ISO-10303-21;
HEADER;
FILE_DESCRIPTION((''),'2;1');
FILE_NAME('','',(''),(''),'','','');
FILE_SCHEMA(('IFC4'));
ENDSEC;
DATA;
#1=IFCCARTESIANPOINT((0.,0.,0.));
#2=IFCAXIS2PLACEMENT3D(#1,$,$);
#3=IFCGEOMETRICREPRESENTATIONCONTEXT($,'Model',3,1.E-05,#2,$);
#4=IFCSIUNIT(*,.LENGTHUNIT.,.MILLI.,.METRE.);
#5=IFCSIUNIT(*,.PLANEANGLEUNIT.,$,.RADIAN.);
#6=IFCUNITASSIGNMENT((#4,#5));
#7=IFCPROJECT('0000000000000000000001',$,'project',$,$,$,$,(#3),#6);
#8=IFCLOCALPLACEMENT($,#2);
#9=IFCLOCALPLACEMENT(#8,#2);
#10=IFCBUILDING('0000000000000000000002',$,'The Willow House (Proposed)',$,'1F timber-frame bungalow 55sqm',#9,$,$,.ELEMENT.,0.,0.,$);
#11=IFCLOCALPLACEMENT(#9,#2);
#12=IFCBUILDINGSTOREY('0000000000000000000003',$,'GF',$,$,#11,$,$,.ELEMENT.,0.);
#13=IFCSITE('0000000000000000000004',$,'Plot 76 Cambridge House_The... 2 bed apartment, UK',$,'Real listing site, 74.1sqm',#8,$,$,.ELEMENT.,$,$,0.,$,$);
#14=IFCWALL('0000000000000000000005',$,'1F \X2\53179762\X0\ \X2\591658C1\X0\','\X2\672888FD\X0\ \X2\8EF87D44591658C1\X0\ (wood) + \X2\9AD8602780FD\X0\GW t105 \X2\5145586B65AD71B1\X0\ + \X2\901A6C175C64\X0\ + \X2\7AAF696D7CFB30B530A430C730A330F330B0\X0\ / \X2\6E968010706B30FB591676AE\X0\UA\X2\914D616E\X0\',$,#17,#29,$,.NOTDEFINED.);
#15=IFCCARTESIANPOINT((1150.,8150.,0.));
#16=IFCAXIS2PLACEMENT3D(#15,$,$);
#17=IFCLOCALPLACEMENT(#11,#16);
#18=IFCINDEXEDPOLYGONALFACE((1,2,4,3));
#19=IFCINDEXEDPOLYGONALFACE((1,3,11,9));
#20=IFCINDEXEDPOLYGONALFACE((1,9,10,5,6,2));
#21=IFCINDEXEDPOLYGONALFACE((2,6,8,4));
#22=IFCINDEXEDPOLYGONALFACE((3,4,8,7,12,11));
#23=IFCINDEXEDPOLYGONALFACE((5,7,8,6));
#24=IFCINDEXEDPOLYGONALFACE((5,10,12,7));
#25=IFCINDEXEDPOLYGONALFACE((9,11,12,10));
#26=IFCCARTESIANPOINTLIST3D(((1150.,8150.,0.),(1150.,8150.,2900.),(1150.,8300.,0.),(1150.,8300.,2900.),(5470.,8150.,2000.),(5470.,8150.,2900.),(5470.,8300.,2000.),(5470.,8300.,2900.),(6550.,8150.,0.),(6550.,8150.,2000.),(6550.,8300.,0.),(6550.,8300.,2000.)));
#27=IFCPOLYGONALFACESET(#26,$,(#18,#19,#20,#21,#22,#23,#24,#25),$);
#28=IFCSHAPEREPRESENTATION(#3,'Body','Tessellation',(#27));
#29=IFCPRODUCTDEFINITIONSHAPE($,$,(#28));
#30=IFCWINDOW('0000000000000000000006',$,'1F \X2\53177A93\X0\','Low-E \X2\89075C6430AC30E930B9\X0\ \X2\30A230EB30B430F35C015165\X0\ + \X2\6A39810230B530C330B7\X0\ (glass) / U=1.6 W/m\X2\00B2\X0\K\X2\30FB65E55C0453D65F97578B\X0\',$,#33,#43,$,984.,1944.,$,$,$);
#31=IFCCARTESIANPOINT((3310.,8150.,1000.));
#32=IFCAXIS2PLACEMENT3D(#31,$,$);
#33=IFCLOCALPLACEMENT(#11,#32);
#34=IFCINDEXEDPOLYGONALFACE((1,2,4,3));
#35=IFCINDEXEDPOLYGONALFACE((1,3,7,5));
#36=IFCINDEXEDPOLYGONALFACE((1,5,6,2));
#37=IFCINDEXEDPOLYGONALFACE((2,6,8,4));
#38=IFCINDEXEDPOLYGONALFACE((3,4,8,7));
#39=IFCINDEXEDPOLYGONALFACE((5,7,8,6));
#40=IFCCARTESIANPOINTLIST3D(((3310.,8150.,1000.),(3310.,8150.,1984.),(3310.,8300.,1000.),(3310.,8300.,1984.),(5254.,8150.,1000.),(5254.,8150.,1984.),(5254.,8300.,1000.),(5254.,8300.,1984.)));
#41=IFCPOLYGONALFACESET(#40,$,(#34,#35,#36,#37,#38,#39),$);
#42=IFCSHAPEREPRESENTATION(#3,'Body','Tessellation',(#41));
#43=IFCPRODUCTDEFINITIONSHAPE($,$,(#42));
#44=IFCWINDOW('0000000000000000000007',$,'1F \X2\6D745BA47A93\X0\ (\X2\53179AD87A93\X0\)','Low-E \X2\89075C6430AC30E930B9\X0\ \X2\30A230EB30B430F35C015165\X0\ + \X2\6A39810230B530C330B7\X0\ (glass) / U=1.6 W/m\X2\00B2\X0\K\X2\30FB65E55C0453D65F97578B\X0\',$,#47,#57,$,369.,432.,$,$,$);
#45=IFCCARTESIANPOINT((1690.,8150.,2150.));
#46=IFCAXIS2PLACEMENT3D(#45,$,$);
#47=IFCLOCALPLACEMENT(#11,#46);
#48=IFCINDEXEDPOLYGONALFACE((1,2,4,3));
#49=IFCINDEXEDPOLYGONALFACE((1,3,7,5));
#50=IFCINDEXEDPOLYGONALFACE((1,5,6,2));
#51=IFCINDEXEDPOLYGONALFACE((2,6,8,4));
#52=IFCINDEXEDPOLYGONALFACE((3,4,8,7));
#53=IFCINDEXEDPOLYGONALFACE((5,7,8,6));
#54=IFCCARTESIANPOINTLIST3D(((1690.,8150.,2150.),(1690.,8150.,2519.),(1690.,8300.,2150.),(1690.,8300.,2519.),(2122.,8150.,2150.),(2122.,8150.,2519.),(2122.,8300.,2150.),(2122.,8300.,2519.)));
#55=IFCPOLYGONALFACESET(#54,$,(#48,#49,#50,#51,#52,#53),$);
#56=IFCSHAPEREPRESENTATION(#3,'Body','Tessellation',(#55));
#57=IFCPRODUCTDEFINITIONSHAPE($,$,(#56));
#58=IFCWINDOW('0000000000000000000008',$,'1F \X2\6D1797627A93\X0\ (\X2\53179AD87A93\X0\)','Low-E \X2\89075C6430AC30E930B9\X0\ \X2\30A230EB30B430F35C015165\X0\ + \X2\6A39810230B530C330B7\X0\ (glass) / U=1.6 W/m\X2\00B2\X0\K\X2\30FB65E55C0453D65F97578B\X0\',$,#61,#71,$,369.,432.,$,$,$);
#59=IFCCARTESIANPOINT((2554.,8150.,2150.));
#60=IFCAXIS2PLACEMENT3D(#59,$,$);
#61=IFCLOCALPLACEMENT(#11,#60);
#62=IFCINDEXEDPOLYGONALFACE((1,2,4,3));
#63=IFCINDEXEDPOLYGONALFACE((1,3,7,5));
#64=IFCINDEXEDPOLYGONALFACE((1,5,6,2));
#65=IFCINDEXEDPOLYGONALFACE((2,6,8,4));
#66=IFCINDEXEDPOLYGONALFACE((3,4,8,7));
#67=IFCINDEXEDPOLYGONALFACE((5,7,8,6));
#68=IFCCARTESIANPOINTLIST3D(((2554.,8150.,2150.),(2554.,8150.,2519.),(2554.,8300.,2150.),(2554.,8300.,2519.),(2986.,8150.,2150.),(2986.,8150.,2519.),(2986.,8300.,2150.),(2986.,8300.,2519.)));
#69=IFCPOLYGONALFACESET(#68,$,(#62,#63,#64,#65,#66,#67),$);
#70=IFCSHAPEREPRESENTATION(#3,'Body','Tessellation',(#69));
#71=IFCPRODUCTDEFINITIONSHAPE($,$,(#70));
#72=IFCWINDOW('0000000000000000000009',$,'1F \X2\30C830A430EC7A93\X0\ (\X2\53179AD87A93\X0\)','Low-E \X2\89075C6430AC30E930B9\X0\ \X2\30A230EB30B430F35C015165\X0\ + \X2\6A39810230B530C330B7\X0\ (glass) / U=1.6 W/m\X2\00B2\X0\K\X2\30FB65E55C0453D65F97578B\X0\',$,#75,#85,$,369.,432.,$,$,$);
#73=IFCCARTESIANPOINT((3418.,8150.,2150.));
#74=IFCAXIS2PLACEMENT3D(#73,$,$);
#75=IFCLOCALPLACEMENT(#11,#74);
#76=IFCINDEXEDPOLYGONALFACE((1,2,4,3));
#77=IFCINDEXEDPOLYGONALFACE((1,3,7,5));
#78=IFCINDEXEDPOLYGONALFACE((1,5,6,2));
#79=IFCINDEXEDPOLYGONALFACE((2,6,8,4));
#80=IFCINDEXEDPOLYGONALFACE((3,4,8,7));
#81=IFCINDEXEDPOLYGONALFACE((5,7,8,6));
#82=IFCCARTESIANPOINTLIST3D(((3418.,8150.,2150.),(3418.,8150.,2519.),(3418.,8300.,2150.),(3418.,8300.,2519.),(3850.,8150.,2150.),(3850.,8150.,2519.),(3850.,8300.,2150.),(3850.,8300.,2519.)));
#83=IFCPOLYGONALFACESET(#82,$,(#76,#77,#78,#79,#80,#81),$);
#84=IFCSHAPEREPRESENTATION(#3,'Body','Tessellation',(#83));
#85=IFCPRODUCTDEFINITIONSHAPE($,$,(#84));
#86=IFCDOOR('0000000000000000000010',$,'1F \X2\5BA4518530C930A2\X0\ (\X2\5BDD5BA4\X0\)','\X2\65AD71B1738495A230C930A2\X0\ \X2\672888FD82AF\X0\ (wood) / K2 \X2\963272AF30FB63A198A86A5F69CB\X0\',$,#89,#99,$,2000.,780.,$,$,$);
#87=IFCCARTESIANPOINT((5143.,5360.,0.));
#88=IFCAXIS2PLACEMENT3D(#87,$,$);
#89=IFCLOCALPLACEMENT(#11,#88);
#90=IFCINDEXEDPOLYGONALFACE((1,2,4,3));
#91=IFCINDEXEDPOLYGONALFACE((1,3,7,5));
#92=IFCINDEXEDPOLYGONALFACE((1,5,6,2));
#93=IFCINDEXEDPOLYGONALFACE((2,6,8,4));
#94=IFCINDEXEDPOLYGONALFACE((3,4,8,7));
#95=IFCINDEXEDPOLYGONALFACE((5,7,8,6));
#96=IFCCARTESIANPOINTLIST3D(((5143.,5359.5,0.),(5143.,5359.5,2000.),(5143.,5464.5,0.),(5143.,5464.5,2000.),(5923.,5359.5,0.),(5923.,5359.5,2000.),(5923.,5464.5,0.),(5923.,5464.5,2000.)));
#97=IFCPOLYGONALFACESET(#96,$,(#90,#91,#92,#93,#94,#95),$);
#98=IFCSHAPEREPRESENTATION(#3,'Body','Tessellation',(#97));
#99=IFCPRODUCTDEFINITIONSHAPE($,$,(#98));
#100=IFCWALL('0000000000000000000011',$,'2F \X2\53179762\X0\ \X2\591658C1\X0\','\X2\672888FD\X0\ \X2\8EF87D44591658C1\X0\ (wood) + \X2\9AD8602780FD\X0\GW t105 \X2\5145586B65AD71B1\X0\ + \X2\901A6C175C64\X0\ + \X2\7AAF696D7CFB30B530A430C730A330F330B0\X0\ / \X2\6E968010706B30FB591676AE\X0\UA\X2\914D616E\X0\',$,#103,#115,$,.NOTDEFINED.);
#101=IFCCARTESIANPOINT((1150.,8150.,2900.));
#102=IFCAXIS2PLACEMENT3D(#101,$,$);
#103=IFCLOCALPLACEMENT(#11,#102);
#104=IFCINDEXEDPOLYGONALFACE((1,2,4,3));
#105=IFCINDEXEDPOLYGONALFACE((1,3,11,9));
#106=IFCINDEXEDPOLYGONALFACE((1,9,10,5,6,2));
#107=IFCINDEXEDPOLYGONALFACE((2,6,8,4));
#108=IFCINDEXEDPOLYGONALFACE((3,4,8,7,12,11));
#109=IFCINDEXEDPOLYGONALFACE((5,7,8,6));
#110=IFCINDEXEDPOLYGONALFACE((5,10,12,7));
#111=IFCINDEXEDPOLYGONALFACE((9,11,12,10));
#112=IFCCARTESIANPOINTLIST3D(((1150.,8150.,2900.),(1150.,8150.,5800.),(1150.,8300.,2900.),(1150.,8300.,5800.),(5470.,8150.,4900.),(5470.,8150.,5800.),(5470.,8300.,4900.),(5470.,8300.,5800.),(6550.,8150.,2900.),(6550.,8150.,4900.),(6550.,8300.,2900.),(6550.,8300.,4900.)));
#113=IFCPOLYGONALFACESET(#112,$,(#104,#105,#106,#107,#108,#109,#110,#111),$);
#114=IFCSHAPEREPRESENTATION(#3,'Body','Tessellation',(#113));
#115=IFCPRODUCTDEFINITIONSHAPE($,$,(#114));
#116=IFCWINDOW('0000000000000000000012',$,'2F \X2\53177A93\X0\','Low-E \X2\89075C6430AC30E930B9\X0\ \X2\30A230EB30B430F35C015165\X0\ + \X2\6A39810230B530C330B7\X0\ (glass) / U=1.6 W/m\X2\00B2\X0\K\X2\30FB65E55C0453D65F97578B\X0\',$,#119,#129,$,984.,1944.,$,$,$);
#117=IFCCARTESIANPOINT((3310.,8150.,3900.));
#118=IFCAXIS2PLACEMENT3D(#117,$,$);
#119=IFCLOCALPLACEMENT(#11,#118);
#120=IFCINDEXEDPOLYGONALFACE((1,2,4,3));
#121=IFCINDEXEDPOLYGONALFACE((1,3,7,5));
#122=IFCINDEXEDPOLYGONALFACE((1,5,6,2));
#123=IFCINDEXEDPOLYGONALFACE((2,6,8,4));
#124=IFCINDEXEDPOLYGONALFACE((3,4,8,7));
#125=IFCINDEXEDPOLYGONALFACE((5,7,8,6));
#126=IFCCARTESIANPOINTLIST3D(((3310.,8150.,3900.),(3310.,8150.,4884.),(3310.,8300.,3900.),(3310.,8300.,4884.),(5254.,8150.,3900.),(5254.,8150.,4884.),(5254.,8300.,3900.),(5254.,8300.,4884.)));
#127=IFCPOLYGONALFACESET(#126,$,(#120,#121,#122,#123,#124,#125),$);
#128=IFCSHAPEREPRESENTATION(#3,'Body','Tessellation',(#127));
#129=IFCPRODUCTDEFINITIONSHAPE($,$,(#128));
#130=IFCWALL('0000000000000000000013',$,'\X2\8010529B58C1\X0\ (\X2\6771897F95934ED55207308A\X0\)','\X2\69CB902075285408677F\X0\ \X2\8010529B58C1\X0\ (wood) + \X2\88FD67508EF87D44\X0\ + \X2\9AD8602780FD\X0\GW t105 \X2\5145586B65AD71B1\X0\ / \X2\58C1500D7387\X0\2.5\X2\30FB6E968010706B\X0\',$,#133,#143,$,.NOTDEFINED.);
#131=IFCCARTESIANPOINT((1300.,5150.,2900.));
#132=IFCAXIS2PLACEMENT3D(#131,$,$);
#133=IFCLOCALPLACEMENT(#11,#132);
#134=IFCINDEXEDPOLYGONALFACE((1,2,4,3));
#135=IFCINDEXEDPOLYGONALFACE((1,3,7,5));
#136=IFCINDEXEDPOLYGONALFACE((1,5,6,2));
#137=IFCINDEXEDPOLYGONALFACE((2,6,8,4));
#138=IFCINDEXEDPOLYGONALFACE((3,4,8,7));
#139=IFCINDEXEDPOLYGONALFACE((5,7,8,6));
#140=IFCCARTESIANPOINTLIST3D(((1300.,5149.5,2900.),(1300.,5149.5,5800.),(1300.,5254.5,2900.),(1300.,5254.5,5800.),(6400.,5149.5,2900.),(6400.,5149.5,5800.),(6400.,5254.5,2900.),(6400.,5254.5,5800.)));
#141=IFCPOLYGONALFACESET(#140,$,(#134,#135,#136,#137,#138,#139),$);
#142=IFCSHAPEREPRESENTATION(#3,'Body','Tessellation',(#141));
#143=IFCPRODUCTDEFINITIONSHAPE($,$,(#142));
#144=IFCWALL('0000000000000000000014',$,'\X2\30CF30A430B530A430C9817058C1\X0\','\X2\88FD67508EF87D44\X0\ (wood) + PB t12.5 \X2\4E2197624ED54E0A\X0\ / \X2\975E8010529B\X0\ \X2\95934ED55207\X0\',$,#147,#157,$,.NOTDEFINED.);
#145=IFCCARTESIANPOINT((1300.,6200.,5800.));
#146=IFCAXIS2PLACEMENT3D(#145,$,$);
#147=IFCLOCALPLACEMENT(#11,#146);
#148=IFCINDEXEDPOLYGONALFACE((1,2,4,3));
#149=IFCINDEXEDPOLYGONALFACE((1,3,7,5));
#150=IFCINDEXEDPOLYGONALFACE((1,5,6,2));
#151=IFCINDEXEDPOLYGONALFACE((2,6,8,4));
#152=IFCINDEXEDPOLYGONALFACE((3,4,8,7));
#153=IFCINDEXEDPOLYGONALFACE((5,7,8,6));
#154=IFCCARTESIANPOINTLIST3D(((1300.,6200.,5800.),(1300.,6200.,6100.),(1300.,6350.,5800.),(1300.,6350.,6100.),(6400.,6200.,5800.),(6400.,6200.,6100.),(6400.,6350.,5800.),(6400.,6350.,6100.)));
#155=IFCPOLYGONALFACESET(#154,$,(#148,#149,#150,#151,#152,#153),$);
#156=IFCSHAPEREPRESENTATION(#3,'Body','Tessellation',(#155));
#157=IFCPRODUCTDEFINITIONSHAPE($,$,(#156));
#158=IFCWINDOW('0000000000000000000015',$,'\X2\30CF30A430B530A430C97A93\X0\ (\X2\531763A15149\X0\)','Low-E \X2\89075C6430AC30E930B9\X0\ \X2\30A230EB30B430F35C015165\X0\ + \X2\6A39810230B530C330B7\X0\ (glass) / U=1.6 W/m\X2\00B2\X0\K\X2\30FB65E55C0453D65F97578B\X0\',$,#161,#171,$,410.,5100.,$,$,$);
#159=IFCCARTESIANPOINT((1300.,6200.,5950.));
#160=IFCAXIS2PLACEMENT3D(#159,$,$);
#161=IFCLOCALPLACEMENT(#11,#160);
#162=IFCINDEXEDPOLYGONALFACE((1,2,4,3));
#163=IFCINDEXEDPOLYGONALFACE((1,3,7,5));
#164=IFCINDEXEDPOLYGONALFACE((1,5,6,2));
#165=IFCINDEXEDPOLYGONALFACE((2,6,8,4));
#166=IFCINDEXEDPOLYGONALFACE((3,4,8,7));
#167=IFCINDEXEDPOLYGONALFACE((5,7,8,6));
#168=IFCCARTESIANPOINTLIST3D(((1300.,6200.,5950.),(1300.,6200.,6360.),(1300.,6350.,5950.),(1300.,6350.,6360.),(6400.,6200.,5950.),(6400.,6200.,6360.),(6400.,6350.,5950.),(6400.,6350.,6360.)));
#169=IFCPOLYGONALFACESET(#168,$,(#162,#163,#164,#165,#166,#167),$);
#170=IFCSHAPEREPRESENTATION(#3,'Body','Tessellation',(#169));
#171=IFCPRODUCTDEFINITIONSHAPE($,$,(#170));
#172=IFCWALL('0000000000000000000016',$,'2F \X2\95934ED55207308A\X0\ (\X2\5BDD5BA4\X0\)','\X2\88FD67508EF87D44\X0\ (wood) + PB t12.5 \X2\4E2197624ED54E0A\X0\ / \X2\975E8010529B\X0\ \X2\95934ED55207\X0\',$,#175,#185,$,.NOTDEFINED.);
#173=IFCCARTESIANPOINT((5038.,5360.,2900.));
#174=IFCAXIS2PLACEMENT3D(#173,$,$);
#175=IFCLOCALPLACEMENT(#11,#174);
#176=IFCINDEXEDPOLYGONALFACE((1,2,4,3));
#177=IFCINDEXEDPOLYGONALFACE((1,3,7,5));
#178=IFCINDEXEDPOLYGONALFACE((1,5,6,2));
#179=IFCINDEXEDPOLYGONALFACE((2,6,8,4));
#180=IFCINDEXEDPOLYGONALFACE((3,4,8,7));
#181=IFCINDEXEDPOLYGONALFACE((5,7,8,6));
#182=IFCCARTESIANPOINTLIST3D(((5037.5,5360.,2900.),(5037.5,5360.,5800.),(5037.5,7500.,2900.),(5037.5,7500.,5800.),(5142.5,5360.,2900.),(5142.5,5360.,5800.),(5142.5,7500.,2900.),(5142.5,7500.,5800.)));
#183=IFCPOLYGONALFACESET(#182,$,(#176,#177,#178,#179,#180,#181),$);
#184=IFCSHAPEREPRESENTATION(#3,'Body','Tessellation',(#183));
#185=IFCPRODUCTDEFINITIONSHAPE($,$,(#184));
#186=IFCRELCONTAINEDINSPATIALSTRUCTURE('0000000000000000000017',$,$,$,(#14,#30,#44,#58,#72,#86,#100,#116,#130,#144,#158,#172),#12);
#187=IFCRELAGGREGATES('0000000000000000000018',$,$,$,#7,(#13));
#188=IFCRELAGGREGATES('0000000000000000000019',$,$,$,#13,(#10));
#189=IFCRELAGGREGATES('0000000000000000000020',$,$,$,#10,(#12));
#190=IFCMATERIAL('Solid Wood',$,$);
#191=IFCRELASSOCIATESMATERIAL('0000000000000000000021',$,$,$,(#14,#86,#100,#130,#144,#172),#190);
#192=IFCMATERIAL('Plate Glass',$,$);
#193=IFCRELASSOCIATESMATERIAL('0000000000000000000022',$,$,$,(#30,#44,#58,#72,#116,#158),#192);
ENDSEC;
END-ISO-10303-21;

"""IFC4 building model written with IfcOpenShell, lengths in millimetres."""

from ifc_helpers import new_model, si_unit, frame, frame_2d, origin, place, context, project, spatial, rectangle, extrude, material, element, fill, save


model = new_model("IFC4")

# Units and contexts
model_context = context("Model", 3, precision=1e-05, world=origin())
ifc_project = project(units=[si_unit("LENGTHUNIT", "METRE", prefix="MILLI"), si_unit("PLANEANGLEUNIT", "RADIAN")], contexts=[model_context])

# Site, building, storey
site_placement = place(None, origin())
site = spatial("IfcSite", under=ifc_project, at=site_placement, Name="Plot 76 Cambridge House_The... 2 bed apartment, UK", ObjectType="Real listing site, 74.1sqm", CompositionType="ELEMENT", RefElevation=0.0)
building_placement = place(site_placement, origin())
building = spatial("IfcBuilding", under=site, at=building_placement, Name="The Willow House (Proposed)", ObjectType="1F timber-frame bungalow 55sqm", CompositionType="ELEMENT", ElevationOfRefHeight=0.0, ElevationOfTerrain=0.0)
storey_placement = place(building_placement, origin())
storey = spatial("IfcBuildingStorey", under=building, at=storey_placement, Name="GF", CompositionType="ELEMENT", Elevation=0.0)

# Wall, openings, windows
ifc_material_1 = material(Name="Solid Wood")
wall_1_placement = place(storey_placement, frame((1150.0, 8150.0, 0.0)))
wall_1 = element("IfcWall", 1, at=wall_1_placement, inside=storey, material=ifc_material_1, Name="1F 北面 外壁", Description="木製 軸組外壁 (wood) + 高性能GW t105 充填断熱 + 通気層 + 窯業系サイディング / 準耐火・外皮UA配慮", PredefinedType="NOTDEFINED", context=model_context, shape_type="SweptSolid", body=[
    extrude(rectangle(XDim=5400.0, YDim=150.0, at=frame_2d((2700.0, 75.0))), frame((1150.0, 8150.0, 0.0)), (0.0, 0.0, 1.0), 2900.0),
])
opening_1_placement = place(storey_placement, frame((3310.0, 8150.0, 1000.0)))
opening_1 = element("IfcOpeningElement", 2, at=opening_1_placement, cuts=wall_1, PredefinedType="NOTDEFINED", context=model_context, shape_type="SweptSolid", body=[
    extrude(rectangle(XDim=1944.0, YDim=150.0, at=frame_2d((972.0, 75.0))), frame((3310.0, 8150.0, 1000.0)), (0.0, 0.0, 1.0), 984.0),
])
opening_2_placement = place(storey_placement, frame((1690.0, 8150.0, 2150.0)))
opening_2 = element("IfcOpeningElement", 3, at=opening_2_placement, cuts=wall_1, PredefinedType="NOTDEFINED", context=model_context, shape_type="SweptSolid", body=[
    extrude(rectangle(XDim=432.0, YDim=150.0, at=frame_2d((216.0, 75.0))), frame((1690.0, 8150.0, 2150.0)), (0.0, 0.0, 1.0), 369.0),
])
opening_3_placement = place(storey_placement, frame((2554.0, 8150.0, 2150.0)))
opening_3 = element("IfcOpeningElement", 4, at=opening_3_placement, cuts=wall_1, PredefinedType="NOTDEFINED", context=model_context, shape_type="SweptSolid", body=[
    extrude(rectangle(XDim=432.0, YDim=150.0, at=frame_2d((216.0, 75.0))), frame((2554.0, 8150.0, 2150.0)), (0.0, 0.0, 1.0), 369.0),
])
opening_4_placement = place(storey_placement, frame((3418.0, 8150.0, 2150.0)))
opening_4 = element("IfcOpeningElement", 5, at=opening_4_placement, cuts=wall_1, PredefinedType="NOTDEFINED", context=model_context, shape_type="SweptSolid", body=[
    extrude(rectangle(XDim=432.0, YDim=150.0, at=frame_2d((216.0, 75.0))), frame((3418.0, 8150.0, 2150.0)), (0.0, 0.0, 1.0), 369.0),
])
ifc_material_2 = material(Name="Plate Glass")
window_1_placement = place(storey_placement, frame((3310.0, 8150.0, 1000.0)))
window_1 = element("IfcWindow", 6, at=window_1_placement, inside=storey, material=ifc_material_2, Name="1F 北窓", Description="Low-E 複層ガラス アルゴン封入 + 樹脂サッシ (glass) / U=1.6 W/m²K・日射取得型", OverallHeight=984.0, OverallWidth=1944.0, context=model_context, shape_type="SweptSolid", body=[
    extrude(rectangle(XDim=1944.0, YDim=150.0, at=frame_2d((972.0, 75.0))), frame((3310.0, 8150.0, 1000.0)), (0.0, 0.0, 1.0), 984.0),
])
fill(opening_1, window_1)
window_2_placement = place(storey_placement, frame((1690.0, 8150.0, 2150.0)))
window_2 = element("IfcWindow", 7, at=window_2_placement, inside=storey, material=ifc_material_2, Name="1F 浴室窓 (北高窓)", Description="Low-E 複層ガラス アルゴン封入 + 樹脂サッシ (glass) / U=1.6 W/m²K・日射取得型", OverallHeight=369.0, OverallWidth=432.0, context=model_context, shape_type="SweptSolid", body=[
    extrude(rectangle(XDim=432.0, YDim=150.0, at=frame_2d((216.0, 75.0))), frame((1690.0, 8150.0, 2150.0)), (0.0, 0.0, 1.0), 369.0),
])
fill(opening_2, window_2)
window_3_placement = place(storey_placement, frame((2554.0, 8150.0, 2150.0)))
window_3 = element("IfcWindow", 8, at=window_3_placement, inside=storey, material=ifc_material_2, Name="1F 洗面窓 (北高窓)", Description="Low-E 複層ガラス アルゴン封入 + 樹脂サッシ (glass) / U=1.6 W/m²K・日射取得型", OverallHeight=369.0, OverallWidth=432.0, context=model_context, shape_type="SweptSolid", body=[
    extrude(rectangle(XDim=432.0, YDim=150.0, at=frame_2d((216.0, 75.0))), frame((2554.0, 8150.0, 2150.0)), (0.0, 0.0, 1.0), 369.0),
])
fill(opening_3, window_3)
window_4_placement = place(storey_placement, frame((3418.0, 8150.0, 2150.0)))
window_4 = element("IfcWindow", 9, at=window_4_placement, inside=storey, material=ifc_material_2, Name="1F トイレ窓 (北高窓)", Description="Low-E 複層ガラス アルゴン封入 + 樹脂サッシ (glass) / U=1.6 W/m²K・日射取得型", OverallHeight=369.0, OverallWidth=432.0, context=model_context, shape_type="SweptSolid", body=[
    extrude(rectangle(XDim=432.0, YDim=150.0, at=frame_2d((216.0, 75.0))), frame((3418.0, 8150.0, 2150.0)), (0.0, 0.0, 1.0), 369.0),
])
fill(opening_4, window_4)

# Door
door_1_placement = place(storey_placement, frame((5143.0, 5360.0, 0.0)))
element("IfcDoor", 10, at=door_1_placement, inside=storey, material=ifc_material_1, Name="1F 室内ドア (寝室)", Description="断熱玄関ドア 木製芯 (wood) / K2 防犯・採風機構", OverallHeight=2000.0, OverallWidth=780.0, context=model_context, shape_type="SweptSolid", body=[
    extrude(rectangle(XDim=780.0, YDim=105.0, at=frame_2d((390.0, 52.0))), frame((5143.0, 5360.0, 0.0)), (0.0, 0.0, 1.0), 2000.0),
])

# Wall, opening, window
wall_2_placement = place(storey_placement, frame((1150.0, 8150.0, 2900.0)))
wall_2 = element("IfcWall", 11, at=wall_2_placement, inside=storey, material=ifc_material_1, Name="2F 北面 外壁", Description="木製 軸組外壁 (wood) + 高性能GW t105 充填断熱 + 通気層 + 窯業系サイディング / 準耐火・外皮UA配慮", PredefinedType="NOTDEFINED", context=model_context, shape_type="SweptSolid", body=[
    extrude(rectangle(XDim=5400.0, YDim=150.0, at=frame_2d((2700.0, 75.0))), frame((1150.0, 8150.0, 2900.0)), (0.0, 0.0, 1.0), 2900.0),
])
opening_5_placement = place(storey_placement, frame((3310.0, 8150.0, 3900.0)))
opening_5 = element("IfcOpeningElement", 12, at=opening_5_placement, cuts=wall_2, PredefinedType="NOTDEFINED", context=model_context, shape_type="SweptSolid", body=[
    extrude(rectangle(XDim=1944.0, YDim=150.0, at=frame_2d((972.0, 75.0))), frame((3310.0, 8150.0, 3900.0)), (0.0, 0.0, 1.0), 984.0),
])
window_5_placement = place(storey_placement, frame((3310.0, 8150.0, 3900.0)))
window_5 = element("IfcWindow", 13, at=window_5_placement, inside=storey, material=ifc_material_2, Name="2F 北窓", Description="Low-E 複層ガラス アルゴン封入 + 樹脂サッシ (glass) / U=1.6 W/m²K・日射取得型", OverallHeight=984.0, OverallWidth=1944.0, context=model_context, shape_type="SweptSolid", body=[
    extrude(rectangle(XDim=1944.0, YDim=150.0, at=frame_2d((972.0, 75.0))), frame((3310.0, 8150.0, 3900.0)), (0.0, 0.0, 1.0), 984.0),
])
fill(opening_5, window_5)

# Wall
wall_3_placement = place(storey_placement, frame((1300.0, 5150.0, 2900.0)))
element("IfcWall", 14, at=wall_3_placement, inside=storey, material=ifc_material_1, Name="耐力壁 (東西間仕切り)", Description="構造用合板 耐力壁 (wood) + 製材軸組 + 高性能GW t105 充填断熱 / 壁倍率2.5・準耐火", PredefinedType="NOTDEFINED", context=model_context, shape_type="SweptSolid", body=[
    extrude(rectangle(XDim=5100.0, YDim=105.0, at=frame_2d((2550.0, 52.0))), frame((1300.0, 5150.0, 2900.0)), (0.0, 0.0, 1.0), 2900.0),
])

# Wall, opening, window
wall_4_placement = place(storey_placement, frame((1300.0, 6200.0, 5800.0)))
wall_4 = element("IfcWall", 15, at=wall_4_placement, inside=storey, material=ifc_material_1, Name="ハイサイド腰壁", Description="製材軸組 (wood) + PB t12.5 両面仕上 / 非耐力 間仕切", PredefinedType="NOTDEFINED", context=model_context, shape_type="SweptSolid", body=[
    extrude(rectangle(XDim=5100.0, YDim=150.0, at=frame_2d((2550.0, 75.0))), frame((1300.0, 6200.0, 5800.0)), (0.0, 0.0, 1.0), 700.0),
])
opening_6_placement = place(storey_placement, frame((1300.0, 6200.0, 5950.0)))
opening_6 = element("IfcOpeningElement", 16, at=opening_6_placement, cuts=wall_4, PredefinedType="NOTDEFINED", context=model_context, shape_type="SweptSolid", body=[
    extrude(rectangle(XDim=5100.0, YDim=150.0, at=frame_2d((2550.0, 75.0))), frame((1300.0, 6200.0, 5950.0)), (0.0, 0.0, 1.0), 410.0),
])
window_6_placement = place(storey_placement, frame((1300.0, 6200.0, 5950.0)))
window_6 = element("IfcWindow", 17, at=window_6_placement, inside=storey, material=ifc_material_2, Name="ハイサイド窓 (北採光)", Description="Low-E 複層ガラス アルゴン封入 + 樹脂サッシ (glass) / U=1.6 W/m²K・日射取得型", OverallHeight=410.0, OverallWidth=5100.0, context=model_context, shape_type="SweptSolid", body=[
    extrude(rectangle(XDim=5100.0, YDim=150.0, at=frame_2d((2550.0, 75.0))), frame((1300.0, 6200.0, 5950.0)), (0.0, 0.0, 1.0), 410.0),
])
fill(opening_6, window_6)

# Wall
wall_5_placement = place(storey_placement, frame((5038.0, 5360.0, 2900.0)))
element("IfcWall", 18, at=wall_5_placement, inside=storey, material=ifc_material_1, Name="2F 間仕切り (寝室)", Description="製材軸組 (wood) + PB t12.5 両面仕上 / 非耐力 間仕切", PredefinedType="NOTDEFINED", context=model_context, shape_type="SweptSolid", body=[
    extrude(rectangle(XDim=105.0, YDim=2140.0, at=frame_2d((52.0, 1070.0))), frame((5038.0, 5360.0, 2900.0)), (0.0, 0.0, 1.0), 2900.0),
])

save(model, "model.ifc")
